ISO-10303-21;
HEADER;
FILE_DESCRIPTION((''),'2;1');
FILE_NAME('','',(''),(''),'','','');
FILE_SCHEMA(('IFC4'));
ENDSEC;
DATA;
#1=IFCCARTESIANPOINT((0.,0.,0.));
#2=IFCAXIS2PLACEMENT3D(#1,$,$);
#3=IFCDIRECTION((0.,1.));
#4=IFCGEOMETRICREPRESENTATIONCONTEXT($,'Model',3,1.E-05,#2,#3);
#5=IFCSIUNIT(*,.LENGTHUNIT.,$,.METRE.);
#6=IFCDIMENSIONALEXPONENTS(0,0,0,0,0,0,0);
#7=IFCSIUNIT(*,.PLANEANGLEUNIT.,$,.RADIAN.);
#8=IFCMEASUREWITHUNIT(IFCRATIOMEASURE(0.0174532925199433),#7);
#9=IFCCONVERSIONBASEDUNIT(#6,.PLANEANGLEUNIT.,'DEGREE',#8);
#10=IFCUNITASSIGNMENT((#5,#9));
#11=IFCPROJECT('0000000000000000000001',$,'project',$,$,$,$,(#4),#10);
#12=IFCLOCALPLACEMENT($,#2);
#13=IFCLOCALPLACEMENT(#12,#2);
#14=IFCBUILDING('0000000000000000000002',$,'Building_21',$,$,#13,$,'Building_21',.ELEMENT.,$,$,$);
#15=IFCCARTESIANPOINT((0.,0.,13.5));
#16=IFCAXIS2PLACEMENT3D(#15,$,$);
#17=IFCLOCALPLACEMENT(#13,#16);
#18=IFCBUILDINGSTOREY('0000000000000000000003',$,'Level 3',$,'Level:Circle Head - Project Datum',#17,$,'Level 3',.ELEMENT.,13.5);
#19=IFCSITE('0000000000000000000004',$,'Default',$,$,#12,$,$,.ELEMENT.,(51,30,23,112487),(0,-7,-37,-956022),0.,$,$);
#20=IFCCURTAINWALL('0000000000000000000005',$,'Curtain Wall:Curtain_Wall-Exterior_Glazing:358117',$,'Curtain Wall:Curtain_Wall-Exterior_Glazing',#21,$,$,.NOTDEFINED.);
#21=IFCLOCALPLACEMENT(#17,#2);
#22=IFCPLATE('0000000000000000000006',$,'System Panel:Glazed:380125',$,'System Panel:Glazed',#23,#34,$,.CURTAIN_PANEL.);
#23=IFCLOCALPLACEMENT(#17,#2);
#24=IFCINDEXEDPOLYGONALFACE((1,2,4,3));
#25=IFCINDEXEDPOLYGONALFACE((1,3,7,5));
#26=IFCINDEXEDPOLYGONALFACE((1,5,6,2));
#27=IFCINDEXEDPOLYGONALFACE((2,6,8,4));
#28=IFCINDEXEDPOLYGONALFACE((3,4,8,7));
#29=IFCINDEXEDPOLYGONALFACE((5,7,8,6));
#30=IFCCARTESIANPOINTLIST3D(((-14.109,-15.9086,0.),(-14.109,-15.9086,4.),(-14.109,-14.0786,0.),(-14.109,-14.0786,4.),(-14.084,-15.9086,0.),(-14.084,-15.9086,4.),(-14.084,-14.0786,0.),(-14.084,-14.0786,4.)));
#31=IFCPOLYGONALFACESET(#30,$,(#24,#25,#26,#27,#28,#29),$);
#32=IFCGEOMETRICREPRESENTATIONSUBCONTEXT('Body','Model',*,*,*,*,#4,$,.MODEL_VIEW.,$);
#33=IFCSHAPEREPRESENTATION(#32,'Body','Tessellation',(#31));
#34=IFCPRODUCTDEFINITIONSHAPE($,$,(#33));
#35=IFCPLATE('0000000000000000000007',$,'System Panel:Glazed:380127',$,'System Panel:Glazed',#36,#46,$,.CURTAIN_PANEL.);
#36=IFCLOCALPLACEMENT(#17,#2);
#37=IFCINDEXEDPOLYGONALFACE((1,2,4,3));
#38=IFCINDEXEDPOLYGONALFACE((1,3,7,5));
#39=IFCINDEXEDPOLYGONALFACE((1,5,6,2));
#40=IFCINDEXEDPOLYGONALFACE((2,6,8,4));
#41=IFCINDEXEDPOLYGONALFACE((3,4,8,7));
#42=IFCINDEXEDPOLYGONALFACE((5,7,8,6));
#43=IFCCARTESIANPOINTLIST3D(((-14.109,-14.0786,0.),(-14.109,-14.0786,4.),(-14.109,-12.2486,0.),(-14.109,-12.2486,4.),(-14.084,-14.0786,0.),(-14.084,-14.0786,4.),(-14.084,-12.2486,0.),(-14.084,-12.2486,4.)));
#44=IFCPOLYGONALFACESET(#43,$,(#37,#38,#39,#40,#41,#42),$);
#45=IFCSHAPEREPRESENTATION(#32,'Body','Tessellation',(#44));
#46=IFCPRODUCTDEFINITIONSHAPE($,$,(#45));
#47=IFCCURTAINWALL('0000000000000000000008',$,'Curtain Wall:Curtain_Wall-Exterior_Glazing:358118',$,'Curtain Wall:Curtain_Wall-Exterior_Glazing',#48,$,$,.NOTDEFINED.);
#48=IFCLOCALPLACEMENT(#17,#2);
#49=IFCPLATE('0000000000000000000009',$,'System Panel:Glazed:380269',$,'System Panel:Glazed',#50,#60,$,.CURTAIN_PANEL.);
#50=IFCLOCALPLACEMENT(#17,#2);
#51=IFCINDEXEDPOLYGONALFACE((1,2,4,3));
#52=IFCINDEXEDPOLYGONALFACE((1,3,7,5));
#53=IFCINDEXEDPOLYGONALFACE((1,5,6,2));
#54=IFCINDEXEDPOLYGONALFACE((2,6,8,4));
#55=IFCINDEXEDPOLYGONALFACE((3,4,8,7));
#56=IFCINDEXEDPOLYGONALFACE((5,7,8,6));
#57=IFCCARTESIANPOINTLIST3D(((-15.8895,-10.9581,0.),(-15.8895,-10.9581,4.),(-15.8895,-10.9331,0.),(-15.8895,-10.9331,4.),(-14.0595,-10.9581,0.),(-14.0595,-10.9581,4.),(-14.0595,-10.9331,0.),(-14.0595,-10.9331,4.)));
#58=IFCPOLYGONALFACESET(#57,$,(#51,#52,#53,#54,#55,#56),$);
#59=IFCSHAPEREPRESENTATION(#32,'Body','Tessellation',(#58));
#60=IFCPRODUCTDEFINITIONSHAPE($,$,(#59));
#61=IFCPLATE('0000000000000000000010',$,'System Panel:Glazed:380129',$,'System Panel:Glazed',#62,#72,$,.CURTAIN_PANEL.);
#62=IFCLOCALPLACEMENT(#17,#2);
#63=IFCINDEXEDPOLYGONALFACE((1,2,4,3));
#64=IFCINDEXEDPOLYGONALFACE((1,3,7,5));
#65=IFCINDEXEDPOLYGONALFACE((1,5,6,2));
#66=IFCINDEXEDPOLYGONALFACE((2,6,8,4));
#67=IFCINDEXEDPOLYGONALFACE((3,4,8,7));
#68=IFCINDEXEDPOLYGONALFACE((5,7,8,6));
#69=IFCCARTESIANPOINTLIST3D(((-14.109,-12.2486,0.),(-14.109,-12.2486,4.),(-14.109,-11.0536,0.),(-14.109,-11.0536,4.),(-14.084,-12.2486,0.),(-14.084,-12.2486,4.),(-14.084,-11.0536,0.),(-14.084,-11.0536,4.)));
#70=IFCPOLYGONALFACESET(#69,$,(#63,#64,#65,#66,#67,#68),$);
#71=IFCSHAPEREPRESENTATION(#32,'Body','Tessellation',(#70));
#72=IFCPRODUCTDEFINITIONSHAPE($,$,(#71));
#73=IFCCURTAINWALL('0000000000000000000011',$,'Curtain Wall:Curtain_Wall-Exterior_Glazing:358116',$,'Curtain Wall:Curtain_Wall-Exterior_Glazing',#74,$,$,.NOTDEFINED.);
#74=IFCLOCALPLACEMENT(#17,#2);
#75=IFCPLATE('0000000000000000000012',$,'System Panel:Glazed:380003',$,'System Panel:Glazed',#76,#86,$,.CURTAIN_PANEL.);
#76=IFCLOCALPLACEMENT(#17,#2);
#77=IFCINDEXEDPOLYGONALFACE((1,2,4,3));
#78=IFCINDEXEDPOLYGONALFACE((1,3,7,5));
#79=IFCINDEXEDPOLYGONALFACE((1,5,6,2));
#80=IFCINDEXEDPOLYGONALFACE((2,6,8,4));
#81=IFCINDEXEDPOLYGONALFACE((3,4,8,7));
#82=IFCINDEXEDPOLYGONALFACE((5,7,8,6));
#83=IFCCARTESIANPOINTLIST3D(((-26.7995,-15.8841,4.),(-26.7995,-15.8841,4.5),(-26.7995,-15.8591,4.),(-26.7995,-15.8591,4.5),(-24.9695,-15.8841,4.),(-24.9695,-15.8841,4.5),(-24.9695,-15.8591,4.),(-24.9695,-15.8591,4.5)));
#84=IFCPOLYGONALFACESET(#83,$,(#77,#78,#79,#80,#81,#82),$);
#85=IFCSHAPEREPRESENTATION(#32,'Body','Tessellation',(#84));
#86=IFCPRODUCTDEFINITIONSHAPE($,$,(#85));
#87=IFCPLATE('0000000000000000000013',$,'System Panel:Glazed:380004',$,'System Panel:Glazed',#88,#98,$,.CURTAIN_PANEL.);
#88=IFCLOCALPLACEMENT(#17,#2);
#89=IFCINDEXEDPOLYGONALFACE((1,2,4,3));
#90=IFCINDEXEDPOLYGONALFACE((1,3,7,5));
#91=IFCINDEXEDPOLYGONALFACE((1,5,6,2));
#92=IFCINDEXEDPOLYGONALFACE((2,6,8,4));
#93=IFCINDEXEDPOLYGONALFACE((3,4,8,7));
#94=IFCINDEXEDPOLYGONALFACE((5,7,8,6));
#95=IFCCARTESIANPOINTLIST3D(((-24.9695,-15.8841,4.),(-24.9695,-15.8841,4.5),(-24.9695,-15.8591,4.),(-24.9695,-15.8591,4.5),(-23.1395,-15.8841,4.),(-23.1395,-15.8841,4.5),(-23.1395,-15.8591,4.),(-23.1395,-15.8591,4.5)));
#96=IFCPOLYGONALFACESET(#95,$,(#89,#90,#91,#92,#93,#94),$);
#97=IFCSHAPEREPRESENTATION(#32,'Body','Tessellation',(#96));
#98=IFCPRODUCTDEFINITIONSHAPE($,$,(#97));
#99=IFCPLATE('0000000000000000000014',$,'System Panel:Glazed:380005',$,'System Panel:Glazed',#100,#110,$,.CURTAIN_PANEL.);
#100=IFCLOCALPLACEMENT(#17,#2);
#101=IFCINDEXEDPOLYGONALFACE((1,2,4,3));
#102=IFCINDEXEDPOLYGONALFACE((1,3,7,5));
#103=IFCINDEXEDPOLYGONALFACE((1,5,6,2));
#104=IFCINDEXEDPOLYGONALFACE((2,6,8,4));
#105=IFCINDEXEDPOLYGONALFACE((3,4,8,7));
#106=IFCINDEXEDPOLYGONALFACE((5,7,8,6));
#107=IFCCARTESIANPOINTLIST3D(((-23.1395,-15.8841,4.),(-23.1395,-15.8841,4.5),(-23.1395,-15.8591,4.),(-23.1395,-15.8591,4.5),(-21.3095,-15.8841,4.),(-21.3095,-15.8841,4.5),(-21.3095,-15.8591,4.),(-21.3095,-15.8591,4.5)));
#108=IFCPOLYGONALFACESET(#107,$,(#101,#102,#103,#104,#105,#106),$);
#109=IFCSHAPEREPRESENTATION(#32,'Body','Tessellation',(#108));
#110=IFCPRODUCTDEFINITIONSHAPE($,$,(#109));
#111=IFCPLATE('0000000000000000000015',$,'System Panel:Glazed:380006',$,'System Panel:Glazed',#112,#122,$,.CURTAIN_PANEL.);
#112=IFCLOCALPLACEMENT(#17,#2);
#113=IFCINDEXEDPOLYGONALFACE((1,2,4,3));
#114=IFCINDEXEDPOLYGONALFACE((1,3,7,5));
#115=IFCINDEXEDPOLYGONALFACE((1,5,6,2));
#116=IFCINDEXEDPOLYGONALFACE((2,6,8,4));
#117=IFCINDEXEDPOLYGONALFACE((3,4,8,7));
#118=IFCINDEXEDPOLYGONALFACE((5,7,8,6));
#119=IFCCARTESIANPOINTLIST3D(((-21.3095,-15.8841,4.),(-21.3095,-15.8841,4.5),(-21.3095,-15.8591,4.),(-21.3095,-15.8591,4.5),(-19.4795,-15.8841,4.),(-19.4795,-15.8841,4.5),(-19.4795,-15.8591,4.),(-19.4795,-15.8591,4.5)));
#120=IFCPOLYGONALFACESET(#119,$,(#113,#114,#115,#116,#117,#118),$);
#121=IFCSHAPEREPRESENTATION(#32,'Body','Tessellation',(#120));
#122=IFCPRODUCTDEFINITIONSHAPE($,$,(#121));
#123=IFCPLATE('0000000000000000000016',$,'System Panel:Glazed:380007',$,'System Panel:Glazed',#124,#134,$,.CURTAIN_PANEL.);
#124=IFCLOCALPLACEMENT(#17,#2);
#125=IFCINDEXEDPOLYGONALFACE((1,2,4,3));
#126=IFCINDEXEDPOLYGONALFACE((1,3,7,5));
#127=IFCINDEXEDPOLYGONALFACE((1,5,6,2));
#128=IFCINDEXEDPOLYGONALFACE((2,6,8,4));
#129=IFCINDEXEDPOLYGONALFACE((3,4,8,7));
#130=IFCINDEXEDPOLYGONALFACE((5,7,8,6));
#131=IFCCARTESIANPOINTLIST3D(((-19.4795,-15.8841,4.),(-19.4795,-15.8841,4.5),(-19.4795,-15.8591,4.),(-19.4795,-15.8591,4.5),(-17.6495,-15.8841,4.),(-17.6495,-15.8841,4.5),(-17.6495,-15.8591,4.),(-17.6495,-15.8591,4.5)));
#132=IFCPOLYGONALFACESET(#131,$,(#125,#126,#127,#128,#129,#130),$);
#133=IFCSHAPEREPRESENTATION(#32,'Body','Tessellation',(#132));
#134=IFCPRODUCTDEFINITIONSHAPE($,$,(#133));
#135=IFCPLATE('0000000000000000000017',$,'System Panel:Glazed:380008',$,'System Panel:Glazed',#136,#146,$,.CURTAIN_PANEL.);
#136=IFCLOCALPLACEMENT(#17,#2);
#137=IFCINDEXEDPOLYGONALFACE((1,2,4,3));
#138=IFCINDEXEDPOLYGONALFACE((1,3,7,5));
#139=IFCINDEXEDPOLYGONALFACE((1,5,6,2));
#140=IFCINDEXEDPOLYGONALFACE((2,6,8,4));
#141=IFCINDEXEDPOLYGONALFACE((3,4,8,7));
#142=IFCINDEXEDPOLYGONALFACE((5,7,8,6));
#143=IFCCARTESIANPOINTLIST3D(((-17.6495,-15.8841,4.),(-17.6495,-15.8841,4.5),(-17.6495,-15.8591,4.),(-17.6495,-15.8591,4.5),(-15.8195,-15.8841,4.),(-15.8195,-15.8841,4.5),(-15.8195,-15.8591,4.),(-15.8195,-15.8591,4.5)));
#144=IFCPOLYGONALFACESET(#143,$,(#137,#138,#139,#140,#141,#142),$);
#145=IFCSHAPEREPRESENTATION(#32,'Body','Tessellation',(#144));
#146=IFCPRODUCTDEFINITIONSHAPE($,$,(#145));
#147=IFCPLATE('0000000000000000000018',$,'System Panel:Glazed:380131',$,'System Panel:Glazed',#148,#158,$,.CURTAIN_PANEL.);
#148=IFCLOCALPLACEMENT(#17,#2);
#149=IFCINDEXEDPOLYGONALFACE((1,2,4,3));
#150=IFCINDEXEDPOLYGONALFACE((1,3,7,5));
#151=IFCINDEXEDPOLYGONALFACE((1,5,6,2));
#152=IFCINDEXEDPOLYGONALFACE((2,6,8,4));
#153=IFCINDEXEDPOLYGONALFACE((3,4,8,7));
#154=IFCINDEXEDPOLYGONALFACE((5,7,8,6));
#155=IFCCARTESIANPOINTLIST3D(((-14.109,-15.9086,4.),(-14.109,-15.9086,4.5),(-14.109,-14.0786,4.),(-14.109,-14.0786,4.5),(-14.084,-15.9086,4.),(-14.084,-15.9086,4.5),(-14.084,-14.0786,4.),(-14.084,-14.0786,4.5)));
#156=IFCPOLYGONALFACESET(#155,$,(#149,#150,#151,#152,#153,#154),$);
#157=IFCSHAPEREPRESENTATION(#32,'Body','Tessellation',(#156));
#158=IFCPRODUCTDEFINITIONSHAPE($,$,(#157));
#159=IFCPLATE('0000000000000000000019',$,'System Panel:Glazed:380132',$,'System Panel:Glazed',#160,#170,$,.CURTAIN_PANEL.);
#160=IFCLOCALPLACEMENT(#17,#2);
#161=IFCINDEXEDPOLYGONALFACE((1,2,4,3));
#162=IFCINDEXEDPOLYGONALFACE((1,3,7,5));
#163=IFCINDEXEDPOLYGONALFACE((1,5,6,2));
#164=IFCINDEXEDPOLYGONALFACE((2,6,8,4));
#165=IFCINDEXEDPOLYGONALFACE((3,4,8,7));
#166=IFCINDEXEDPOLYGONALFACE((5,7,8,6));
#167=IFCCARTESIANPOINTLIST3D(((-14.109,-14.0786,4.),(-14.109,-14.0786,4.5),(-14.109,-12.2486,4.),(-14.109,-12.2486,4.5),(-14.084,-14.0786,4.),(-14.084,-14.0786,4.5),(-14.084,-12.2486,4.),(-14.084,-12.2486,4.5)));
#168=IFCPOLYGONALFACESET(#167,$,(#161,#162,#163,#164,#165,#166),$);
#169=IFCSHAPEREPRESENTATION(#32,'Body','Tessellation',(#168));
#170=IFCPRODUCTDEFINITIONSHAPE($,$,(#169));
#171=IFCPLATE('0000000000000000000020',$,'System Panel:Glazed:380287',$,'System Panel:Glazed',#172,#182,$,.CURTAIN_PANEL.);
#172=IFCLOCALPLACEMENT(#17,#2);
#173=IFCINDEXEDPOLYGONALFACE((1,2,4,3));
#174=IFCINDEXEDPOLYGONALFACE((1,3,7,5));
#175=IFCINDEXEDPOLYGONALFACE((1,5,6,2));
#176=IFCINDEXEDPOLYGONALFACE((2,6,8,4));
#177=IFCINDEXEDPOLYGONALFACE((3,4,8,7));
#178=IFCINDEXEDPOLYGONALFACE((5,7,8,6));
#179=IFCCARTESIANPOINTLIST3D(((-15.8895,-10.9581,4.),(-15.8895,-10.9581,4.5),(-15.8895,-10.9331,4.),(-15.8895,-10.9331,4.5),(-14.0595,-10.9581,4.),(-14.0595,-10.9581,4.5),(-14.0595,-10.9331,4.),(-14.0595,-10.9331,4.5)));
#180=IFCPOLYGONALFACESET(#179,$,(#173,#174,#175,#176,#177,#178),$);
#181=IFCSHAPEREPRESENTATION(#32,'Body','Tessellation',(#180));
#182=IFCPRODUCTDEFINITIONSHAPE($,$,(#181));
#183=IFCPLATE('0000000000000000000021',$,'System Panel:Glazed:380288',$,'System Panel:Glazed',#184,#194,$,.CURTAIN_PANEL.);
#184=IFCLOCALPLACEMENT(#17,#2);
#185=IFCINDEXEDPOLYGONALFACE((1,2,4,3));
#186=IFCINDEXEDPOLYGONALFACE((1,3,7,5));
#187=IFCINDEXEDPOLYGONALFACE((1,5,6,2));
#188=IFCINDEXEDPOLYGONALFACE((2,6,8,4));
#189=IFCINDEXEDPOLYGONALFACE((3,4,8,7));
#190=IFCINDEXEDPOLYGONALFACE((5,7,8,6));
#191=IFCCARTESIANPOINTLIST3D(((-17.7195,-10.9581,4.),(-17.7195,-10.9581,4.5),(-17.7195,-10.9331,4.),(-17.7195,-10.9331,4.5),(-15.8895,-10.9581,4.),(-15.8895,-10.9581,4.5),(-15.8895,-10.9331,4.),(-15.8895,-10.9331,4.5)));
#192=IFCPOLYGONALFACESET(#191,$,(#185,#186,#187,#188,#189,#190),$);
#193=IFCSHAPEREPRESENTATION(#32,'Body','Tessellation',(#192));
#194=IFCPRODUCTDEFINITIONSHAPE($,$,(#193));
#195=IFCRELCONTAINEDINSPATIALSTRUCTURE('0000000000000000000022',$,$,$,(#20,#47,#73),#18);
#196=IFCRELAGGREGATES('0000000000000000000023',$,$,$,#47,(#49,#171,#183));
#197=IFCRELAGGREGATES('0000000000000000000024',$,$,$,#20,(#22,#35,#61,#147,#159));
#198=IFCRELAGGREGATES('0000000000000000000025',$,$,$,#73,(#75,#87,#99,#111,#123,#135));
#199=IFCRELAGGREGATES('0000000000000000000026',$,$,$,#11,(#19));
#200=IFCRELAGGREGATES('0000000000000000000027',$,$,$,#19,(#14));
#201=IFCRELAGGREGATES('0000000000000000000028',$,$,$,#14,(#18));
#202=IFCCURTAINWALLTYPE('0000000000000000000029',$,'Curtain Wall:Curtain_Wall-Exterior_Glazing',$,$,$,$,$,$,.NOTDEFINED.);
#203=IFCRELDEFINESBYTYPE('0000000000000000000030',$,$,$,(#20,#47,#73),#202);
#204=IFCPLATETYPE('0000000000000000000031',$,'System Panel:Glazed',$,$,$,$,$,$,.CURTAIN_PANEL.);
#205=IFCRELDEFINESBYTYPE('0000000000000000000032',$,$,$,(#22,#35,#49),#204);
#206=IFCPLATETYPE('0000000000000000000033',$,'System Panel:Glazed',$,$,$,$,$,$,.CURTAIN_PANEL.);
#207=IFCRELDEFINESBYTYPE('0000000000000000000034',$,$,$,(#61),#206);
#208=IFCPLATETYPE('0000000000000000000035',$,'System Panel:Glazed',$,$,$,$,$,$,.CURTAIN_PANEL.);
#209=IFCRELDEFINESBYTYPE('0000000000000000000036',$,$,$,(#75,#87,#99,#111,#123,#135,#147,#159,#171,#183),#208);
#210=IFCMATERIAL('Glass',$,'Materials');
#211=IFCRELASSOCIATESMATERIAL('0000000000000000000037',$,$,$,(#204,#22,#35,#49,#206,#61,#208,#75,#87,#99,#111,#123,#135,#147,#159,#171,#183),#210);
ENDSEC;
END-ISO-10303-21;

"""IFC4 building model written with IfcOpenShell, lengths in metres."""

from ifc_helpers import new_model, entity, si_unit, converted_unit, direction, frame, origin, origin_2d_with_axis, place, context, subcontext, project, spatial, rectangle, extrude, source, transform, mapped, material, type_object, type_shapes, element, aggregate, save


model = new_model("IFC4")

# Units and contexts
model_context = context("Model", 3, precision=1e-05, world=origin(), true_north=direction((0.0, 1.0)))
body_context = subcontext(model_context, "Body", "Model", "MODEL_VIEW")
ifc_project = project(units=[si_unit("LENGTHUNIT", "METRE"), converted_unit("PLANEANGLEUNIT", "DEGREE", entity("IfcRatioMeasure", 0.0174532925199433), si_unit("PLANEANGLEUNIT", "RADIAN"), dimensions=[0, 0, 0, 0, 0, 0, 0])], contexts=[model_context])

# Site, building, storey
site_placement = place(None, origin())
site = spatial("IfcSite", under=ifc_project, at=site_placement, Name="Default", CompositionType="ELEMENT", RefLatitude=(51, 30, 23, 112487), RefLongitude=(0, -7, -37, -956022), RefElevation=0.0)
building_placement = place(site_placement, origin())
building = spatial("IfcBuilding", under=site, at=building_placement, Name="Building_21", LongName="Building_21", CompositionType="ELEMENT")
storey_placement = place(building_placement, frame((0.0, 0.0, 13.5)))
storey = spatial("IfcBuildingStorey", under=building, at=storey_placement, Name="Level 3", ObjectType="Level:Circle Head - Project Datum", LongName="Level 3", CompositionType="ELEMENT", Elevation=13.5)

# Curtain wall, plates
curtain_wall_type = type_object("IfcCurtainWallType", Name="Curtain Wall:Curtain_Wall-Exterior_Glazing", PredefinedType="NOTDEFINED")
curtain_wall_1_placement = place(storey_placement, frame((0.0, 0.0, -13.5)))
curtain_wall_1 = element("IfcCurtainWall", 1, at=curtain_wall_1_placement, inside=storey, type_object=curtain_wall_type, Name="Curtain Wall:Curtain_Wall-Exterior_Glazing:358117", ObjectType="Curtain Wall:Curtain_Wall-Exterior_Glazing", PredefinedType="NOTDEFINED")
ifc_material = material(Name="Glass", Category="Materials")
plate_type_1 = type_object("IfcPlateType", Name="System Panel:Glazed", PredefinedType="CURTAIN_PANEL", material=ifc_material)
shared_shape_1 = source(origin(), body_context, "Body", "SweptSolid", [
    extrude(rectangle(XDim=0.025, YDim=1.83, at=origin_2d_with_axis()), frame((0.915, 0.0125, 0.0), z_axis=(0.0, 0.0, 1.0), x_axis=(0.0, 1.0, 0.0)), (0.0, 0.0, 1.0), 4.0),
])
type_shapes(plate_type_1, [shared_shape_1])
plate_1_placement = place(curtain_wall_1_placement, frame((-14.084, -15.9086, 13.5), z_axis=(0.0, 0.0, 1.0), x_axis=(0.0, 1.0, 0.0)))
plate_1 = element("IfcPlate", 2, at=plate_1_placement, type_object=plate_type_1, material=ifc_material, Name="System Panel:Glazed:380125", ObjectType="System Panel:Glazed", PredefinedType="CURTAIN_PANEL", context=body_context, shape_type="MappedRepresentation", body=[
    mapped(shared_shape_1, transform((0.0, 0.0, 0.0), scale=1.0)),
])
plate_2_placement = place(curtain_wall_1_placement, frame((-14.084, -14.0786, 13.5), z_axis=(0.0, 0.0, 1.0), x_axis=(0.0, 1.0, 0.0)))
plate_2 = element("IfcPlate", 3, at=plate_2_placement, type_object=plate_type_1, material=ifc_material, Name="System Panel:Glazed:380127", ObjectType="System Panel:Glazed", PredefinedType="CURTAIN_PANEL", context=body_context, shape_type="MappedRepresentation", body=[
    mapped(shared_shape_1, transform((0.0, 0.0, 0.0), scale=1.0)),
])

# Curtain wall, plate
curtain_wall_2_placement = place(storey_placement, frame((0.0, 0.0, -13.5)))
curtain_wall_2 = element("IfcCurtainWall", 4, at=curtain_wall_2_placement, inside=storey, type_object=curtain_wall_type, Name="Curtain Wall:Curtain_Wall-Exterior_Glazing:358118", ObjectType="Curtain Wall:Curtain_Wall-Exterior_Glazing", PredefinedType="NOTDEFINED")
plate_3_placement = place(curtain_wall_2_placement, frame((-14.0595, -10.9331, 13.5), z_axis=(0.0, 0.0, 1.0), x_axis=(-1.0, 0.0, 0.0)))
plate_3 = element("IfcPlate", 5, at=plate_3_placement, type_object=plate_type_1, material=ifc_material, Name="System Panel:Glazed:380269", ObjectType="System Panel:Glazed", PredefinedType="CURTAIN_PANEL", context=body_context, shape_type="MappedRepresentation", body=[
    mapped(shared_shape_1, transform((0.0, 0.0, 0.0), scale=1.0)),
])

# Plate
plate_type_2 = type_object("IfcPlateType", Name="System Panel:Glazed", PredefinedType="CURTAIN_PANEL", material=ifc_material)
shared_shape_2 = source(origin(), body_context, "Body", "SweptSolid", [
    extrude(rectangle(XDim=0.025, YDim=1.195, at=origin_2d_with_axis()), frame((0.5975, 0.0125, 0.0), z_axis=(0.0, 0.0, 1.0), x_axis=(0.0, 1.0, 0.0)), (0.0, 0.0, 1.0), 4.0),
])
type_shapes(plate_type_2, [shared_shape_2])
plate_4_placement = place(curtain_wall_1_placement, frame((-14.084, -12.2486, 13.5), z_axis=(0.0, 0.0, 1.0), x_axis=(0.0, 1.0, 0.0)))
plate_4 = element("IfcPlate", 6, at=plate_4_placement, type_object=plate_type_2, material=ifc_material, Name="System Panel:Glazed:380129", ObjectType="System Panel:Glazed", PredefinedType="CURTAIN_PANEL", context=body_context, shape_type="MappedRepresentation", body=[
    mapped(shared_shape_2, transform((0.0, 0.0, 0.0), scale=1.0)),
])

# Curtain wall, plates
curtain_wall_3_placement = place(storey_placement, frame((0.0, 0.0, -13.5)))
curtain_wall_3 = element("IfcCurtainWall", 7, at=curtain_wall_3_placement, inside=storey, type_object=curtain_wall_type, Name="Curtain Wall:Curtain_Wall-Exterior_Glazing:358116", ObjectType="Curtain Wall:Curtain_Wall-Exterior_Glazing", PredefinedType="NOTDEFINED")
plate_type_3 = type_object("IfcPlateType", Name="System Panel:Glazed", PredefinedType="CURTAIN_PANEL", material=ifc_material)
shared_shape_3 = source(origin(), body_context, "Body", "SweptSolid", [
    extrude(rectangle(XDim=0.025, YDim=1.83, at=origin_2d_with_axis()), frame((0.915, 0.0125, 0.0), z_axis=(0.0, 0.0, 1.0), x_axis=(0.0, 1.0, 0.0)), (0.0, 0.0, 1.0), 0.5),
])
type_shapes(plate_type_3, [shared_shape_3])
plate_5_placement = place(curtain_wall_3_placement, frame((-26.7995, -15.8841, 17.5)))
plate_5 = element("IfcPlate", 8, at=plate_5_placement, type_object=plate_type_3, material=ifc_material, Name="System Panel:Glazed:380003", ObjectType="System Panel:Glazed", PredefinedType="CURTAIN_PANEL", context=body_context, shape_type="MappedRepresentation", body=[
    mapped(shared_shape_3, transform((0.0, 0.0, 0.0), scale=1.0)),
])
plate_6_placement = place(curtain_wall_3_placement, frame((-24.9695, -15.8841, 17.5)))
plate_6 = element("IfcPlate", 9, at=plate_6_placement, type_object=plate_type_3, material=ifc_material, Name="System Panel:Glazed:380004", ObjectType="System Panel:Glazed", PredefinedType="CURTAIN_PANEL", context=body_context, shape_type="MappedRepresentation", body=[
    mapped(shared_shape_3, transform((0.0, 0.0, 0.0), scale=1.0)),
])
plate_7_placement = place(curtain_wall_3_placement, frame((-23.1395, -15.8841, 17.5)))
plate_7 = element("IfcPlate", 10, at=plate_7_placement, type_object=plate_type_3, material=ifc_material, Name="System Panel:Glazed:380005", ObjectType="System Panel:Glazed", PredefinedType="CURTAIN_PANEL", context=body_context, shape_type="MappedRepresentation", body=[
    mapped(shared_shape_3, transform((0.0, 0.0, 0.0), scale=1.0)),
])
plate_8_placement = place(curtain_wall_3_placement, frame((-21.3095, -15.8841, 17.5)))
plate_8 = element("IfcPlate", 11, at=plate_8_placement, type_object=plate_type_3, material=ifc_material, Name="System Panel:Glazed:380006", ObjectType="System Panel:Glazed", PredefinedType="CURTAIN_PANEL", context=body_context, shape_type="MappedRepresentation", body=[
    mapped(shared_shape_3, transform((0.0, 0.0, 0.0), scale=1.0)),
])
plate_9_placement = place(curtain_wall_3_placement, frame((-19.4795, -15.8841, 17.5)))
plate_9 = element("IfcPlate", 12, at=plate_9_placement, type_object=plate_type_3, material=ifc_material, Name="System Panel:Glazed:380007", ObjectType="System Panel:Glazed", PredefinedType="CURTAIN_PANEL", context=body_context, shape_type="MappedRepresentation", body=[
    mapped(shared_shape_3, transform((0.0, 0.0, 0.0), scale=1.0)),
])
plate_10_placement = place(curtain_wall_3_placement, frame((-17.6495, -15.8841, 17.5)))
plate_10 = element("IfcPlate", 13, at=plate_10_placement, type_object=plate_type_3, material=ifc_material, Name="System Panel:Glazed:380008", ObjectType="System Panel:Glazed", PredefinedType="CURTAIN_PANEL", context=body_context, shape_type="MappedRepresentation", body=[
    mapped(shared_shape_3, transform((0.0, 0.0, 0.0), scale=1.0)),
])

# Plates
plate_11_placement = place(curtain_wall_1_placement, frame((-14.084, -15.9086, 17.5), z_axis=(0.0, 0.0, 1.0), x_axis=(0.0, 1.0, 0.0)))
plate_11 = element("IfcPlate", 14, at=plate_11_placement, type_object=plate_type_3, material=ifc_material, Name="System Panel:Glazed:380131", ObjectType="System Panel:Glazed", PredefinedType="CURTAIN_PANEL", context=body_context, shape_type="MappedRepresentation", body=[
    mapped(shared_shape_3, transform((0.0, 0.0, 0.0), scale=1.0)),
])
plate_12_placement = place(curtain_wall_1_placement, frame((-14.084, -14.0786, 17.5), z_axis=(0.0, 0.0, 1.0), x_axis=(0.0, 1.0, 0.0)))
plate_12 = element("IfcPlate", 15, at=plate_12_placement, type_object=plate_type_3, material=ifc_material, Name="System Panel:Glazed:380132", ObjectType="System Panel:Glazed", PredefinedType="CURTAIN_PANEL", context=body_context, shape_type="MappedRepresentation", body=[
    mapped(shared_shape_3, transform((0.0, 0.0, 0.0), scale=1.0)),
])
plate_13_placement = place(curtain_wall_2_placement, frame((-14.0595, -10.9331, 17.5), z_axis=(0.0, 0.0, 1.0), x_axis=(-1.0, 0.0, 0.0)))
plate_13 = element("IfcPlate", 16, at=plate_13_placement, type_object=plate_type_3, material=ifc_material, Name="System Panel:Glazed:380287", ObjectType="System Panel:Glazed", PredefinedType="CURTAIN_PANEL", context=body_context, shape_type="MappedRepresentation", body=[
    mapped(shared_shape_3, transform((0.0, 0.0, 0.0), scale=1.0)),
])
plate_14_placement = place(curtain_wall_2_placement, frame((-15.8895, -10.9331, 17.5), z_axis=(0.0, 0.0, 1.0), x_axis=(-1.0, 0.0, 0.0)))
plate_14 = element("IfcPlate", 17, at=plate_14_placement, type_object=plate_type_3, material=ifc_material, Name="System Panel:Glazed:380288", ObjectType="System Panel:Glazed", PredefinedType="CURTAIN_PANEL", context=body_context, shape_type="MappedRepresentation", body=[
    mapped(shared_shape_3, transform((0.0, 0.0, 0.0), scale=1.0)),
])
aggregate(curtain_wall_2, [plate_3, plate_13, plate_14])
aggregate(curtain_wall_1, [plate_1, plate_2, plate_4, plate_11, plate_12])
aggregate(curtain_wall_3, [plate_5, plate_6, plate_7, plate_8, plate_9, plate_10])

save(model, "model.ifc")
